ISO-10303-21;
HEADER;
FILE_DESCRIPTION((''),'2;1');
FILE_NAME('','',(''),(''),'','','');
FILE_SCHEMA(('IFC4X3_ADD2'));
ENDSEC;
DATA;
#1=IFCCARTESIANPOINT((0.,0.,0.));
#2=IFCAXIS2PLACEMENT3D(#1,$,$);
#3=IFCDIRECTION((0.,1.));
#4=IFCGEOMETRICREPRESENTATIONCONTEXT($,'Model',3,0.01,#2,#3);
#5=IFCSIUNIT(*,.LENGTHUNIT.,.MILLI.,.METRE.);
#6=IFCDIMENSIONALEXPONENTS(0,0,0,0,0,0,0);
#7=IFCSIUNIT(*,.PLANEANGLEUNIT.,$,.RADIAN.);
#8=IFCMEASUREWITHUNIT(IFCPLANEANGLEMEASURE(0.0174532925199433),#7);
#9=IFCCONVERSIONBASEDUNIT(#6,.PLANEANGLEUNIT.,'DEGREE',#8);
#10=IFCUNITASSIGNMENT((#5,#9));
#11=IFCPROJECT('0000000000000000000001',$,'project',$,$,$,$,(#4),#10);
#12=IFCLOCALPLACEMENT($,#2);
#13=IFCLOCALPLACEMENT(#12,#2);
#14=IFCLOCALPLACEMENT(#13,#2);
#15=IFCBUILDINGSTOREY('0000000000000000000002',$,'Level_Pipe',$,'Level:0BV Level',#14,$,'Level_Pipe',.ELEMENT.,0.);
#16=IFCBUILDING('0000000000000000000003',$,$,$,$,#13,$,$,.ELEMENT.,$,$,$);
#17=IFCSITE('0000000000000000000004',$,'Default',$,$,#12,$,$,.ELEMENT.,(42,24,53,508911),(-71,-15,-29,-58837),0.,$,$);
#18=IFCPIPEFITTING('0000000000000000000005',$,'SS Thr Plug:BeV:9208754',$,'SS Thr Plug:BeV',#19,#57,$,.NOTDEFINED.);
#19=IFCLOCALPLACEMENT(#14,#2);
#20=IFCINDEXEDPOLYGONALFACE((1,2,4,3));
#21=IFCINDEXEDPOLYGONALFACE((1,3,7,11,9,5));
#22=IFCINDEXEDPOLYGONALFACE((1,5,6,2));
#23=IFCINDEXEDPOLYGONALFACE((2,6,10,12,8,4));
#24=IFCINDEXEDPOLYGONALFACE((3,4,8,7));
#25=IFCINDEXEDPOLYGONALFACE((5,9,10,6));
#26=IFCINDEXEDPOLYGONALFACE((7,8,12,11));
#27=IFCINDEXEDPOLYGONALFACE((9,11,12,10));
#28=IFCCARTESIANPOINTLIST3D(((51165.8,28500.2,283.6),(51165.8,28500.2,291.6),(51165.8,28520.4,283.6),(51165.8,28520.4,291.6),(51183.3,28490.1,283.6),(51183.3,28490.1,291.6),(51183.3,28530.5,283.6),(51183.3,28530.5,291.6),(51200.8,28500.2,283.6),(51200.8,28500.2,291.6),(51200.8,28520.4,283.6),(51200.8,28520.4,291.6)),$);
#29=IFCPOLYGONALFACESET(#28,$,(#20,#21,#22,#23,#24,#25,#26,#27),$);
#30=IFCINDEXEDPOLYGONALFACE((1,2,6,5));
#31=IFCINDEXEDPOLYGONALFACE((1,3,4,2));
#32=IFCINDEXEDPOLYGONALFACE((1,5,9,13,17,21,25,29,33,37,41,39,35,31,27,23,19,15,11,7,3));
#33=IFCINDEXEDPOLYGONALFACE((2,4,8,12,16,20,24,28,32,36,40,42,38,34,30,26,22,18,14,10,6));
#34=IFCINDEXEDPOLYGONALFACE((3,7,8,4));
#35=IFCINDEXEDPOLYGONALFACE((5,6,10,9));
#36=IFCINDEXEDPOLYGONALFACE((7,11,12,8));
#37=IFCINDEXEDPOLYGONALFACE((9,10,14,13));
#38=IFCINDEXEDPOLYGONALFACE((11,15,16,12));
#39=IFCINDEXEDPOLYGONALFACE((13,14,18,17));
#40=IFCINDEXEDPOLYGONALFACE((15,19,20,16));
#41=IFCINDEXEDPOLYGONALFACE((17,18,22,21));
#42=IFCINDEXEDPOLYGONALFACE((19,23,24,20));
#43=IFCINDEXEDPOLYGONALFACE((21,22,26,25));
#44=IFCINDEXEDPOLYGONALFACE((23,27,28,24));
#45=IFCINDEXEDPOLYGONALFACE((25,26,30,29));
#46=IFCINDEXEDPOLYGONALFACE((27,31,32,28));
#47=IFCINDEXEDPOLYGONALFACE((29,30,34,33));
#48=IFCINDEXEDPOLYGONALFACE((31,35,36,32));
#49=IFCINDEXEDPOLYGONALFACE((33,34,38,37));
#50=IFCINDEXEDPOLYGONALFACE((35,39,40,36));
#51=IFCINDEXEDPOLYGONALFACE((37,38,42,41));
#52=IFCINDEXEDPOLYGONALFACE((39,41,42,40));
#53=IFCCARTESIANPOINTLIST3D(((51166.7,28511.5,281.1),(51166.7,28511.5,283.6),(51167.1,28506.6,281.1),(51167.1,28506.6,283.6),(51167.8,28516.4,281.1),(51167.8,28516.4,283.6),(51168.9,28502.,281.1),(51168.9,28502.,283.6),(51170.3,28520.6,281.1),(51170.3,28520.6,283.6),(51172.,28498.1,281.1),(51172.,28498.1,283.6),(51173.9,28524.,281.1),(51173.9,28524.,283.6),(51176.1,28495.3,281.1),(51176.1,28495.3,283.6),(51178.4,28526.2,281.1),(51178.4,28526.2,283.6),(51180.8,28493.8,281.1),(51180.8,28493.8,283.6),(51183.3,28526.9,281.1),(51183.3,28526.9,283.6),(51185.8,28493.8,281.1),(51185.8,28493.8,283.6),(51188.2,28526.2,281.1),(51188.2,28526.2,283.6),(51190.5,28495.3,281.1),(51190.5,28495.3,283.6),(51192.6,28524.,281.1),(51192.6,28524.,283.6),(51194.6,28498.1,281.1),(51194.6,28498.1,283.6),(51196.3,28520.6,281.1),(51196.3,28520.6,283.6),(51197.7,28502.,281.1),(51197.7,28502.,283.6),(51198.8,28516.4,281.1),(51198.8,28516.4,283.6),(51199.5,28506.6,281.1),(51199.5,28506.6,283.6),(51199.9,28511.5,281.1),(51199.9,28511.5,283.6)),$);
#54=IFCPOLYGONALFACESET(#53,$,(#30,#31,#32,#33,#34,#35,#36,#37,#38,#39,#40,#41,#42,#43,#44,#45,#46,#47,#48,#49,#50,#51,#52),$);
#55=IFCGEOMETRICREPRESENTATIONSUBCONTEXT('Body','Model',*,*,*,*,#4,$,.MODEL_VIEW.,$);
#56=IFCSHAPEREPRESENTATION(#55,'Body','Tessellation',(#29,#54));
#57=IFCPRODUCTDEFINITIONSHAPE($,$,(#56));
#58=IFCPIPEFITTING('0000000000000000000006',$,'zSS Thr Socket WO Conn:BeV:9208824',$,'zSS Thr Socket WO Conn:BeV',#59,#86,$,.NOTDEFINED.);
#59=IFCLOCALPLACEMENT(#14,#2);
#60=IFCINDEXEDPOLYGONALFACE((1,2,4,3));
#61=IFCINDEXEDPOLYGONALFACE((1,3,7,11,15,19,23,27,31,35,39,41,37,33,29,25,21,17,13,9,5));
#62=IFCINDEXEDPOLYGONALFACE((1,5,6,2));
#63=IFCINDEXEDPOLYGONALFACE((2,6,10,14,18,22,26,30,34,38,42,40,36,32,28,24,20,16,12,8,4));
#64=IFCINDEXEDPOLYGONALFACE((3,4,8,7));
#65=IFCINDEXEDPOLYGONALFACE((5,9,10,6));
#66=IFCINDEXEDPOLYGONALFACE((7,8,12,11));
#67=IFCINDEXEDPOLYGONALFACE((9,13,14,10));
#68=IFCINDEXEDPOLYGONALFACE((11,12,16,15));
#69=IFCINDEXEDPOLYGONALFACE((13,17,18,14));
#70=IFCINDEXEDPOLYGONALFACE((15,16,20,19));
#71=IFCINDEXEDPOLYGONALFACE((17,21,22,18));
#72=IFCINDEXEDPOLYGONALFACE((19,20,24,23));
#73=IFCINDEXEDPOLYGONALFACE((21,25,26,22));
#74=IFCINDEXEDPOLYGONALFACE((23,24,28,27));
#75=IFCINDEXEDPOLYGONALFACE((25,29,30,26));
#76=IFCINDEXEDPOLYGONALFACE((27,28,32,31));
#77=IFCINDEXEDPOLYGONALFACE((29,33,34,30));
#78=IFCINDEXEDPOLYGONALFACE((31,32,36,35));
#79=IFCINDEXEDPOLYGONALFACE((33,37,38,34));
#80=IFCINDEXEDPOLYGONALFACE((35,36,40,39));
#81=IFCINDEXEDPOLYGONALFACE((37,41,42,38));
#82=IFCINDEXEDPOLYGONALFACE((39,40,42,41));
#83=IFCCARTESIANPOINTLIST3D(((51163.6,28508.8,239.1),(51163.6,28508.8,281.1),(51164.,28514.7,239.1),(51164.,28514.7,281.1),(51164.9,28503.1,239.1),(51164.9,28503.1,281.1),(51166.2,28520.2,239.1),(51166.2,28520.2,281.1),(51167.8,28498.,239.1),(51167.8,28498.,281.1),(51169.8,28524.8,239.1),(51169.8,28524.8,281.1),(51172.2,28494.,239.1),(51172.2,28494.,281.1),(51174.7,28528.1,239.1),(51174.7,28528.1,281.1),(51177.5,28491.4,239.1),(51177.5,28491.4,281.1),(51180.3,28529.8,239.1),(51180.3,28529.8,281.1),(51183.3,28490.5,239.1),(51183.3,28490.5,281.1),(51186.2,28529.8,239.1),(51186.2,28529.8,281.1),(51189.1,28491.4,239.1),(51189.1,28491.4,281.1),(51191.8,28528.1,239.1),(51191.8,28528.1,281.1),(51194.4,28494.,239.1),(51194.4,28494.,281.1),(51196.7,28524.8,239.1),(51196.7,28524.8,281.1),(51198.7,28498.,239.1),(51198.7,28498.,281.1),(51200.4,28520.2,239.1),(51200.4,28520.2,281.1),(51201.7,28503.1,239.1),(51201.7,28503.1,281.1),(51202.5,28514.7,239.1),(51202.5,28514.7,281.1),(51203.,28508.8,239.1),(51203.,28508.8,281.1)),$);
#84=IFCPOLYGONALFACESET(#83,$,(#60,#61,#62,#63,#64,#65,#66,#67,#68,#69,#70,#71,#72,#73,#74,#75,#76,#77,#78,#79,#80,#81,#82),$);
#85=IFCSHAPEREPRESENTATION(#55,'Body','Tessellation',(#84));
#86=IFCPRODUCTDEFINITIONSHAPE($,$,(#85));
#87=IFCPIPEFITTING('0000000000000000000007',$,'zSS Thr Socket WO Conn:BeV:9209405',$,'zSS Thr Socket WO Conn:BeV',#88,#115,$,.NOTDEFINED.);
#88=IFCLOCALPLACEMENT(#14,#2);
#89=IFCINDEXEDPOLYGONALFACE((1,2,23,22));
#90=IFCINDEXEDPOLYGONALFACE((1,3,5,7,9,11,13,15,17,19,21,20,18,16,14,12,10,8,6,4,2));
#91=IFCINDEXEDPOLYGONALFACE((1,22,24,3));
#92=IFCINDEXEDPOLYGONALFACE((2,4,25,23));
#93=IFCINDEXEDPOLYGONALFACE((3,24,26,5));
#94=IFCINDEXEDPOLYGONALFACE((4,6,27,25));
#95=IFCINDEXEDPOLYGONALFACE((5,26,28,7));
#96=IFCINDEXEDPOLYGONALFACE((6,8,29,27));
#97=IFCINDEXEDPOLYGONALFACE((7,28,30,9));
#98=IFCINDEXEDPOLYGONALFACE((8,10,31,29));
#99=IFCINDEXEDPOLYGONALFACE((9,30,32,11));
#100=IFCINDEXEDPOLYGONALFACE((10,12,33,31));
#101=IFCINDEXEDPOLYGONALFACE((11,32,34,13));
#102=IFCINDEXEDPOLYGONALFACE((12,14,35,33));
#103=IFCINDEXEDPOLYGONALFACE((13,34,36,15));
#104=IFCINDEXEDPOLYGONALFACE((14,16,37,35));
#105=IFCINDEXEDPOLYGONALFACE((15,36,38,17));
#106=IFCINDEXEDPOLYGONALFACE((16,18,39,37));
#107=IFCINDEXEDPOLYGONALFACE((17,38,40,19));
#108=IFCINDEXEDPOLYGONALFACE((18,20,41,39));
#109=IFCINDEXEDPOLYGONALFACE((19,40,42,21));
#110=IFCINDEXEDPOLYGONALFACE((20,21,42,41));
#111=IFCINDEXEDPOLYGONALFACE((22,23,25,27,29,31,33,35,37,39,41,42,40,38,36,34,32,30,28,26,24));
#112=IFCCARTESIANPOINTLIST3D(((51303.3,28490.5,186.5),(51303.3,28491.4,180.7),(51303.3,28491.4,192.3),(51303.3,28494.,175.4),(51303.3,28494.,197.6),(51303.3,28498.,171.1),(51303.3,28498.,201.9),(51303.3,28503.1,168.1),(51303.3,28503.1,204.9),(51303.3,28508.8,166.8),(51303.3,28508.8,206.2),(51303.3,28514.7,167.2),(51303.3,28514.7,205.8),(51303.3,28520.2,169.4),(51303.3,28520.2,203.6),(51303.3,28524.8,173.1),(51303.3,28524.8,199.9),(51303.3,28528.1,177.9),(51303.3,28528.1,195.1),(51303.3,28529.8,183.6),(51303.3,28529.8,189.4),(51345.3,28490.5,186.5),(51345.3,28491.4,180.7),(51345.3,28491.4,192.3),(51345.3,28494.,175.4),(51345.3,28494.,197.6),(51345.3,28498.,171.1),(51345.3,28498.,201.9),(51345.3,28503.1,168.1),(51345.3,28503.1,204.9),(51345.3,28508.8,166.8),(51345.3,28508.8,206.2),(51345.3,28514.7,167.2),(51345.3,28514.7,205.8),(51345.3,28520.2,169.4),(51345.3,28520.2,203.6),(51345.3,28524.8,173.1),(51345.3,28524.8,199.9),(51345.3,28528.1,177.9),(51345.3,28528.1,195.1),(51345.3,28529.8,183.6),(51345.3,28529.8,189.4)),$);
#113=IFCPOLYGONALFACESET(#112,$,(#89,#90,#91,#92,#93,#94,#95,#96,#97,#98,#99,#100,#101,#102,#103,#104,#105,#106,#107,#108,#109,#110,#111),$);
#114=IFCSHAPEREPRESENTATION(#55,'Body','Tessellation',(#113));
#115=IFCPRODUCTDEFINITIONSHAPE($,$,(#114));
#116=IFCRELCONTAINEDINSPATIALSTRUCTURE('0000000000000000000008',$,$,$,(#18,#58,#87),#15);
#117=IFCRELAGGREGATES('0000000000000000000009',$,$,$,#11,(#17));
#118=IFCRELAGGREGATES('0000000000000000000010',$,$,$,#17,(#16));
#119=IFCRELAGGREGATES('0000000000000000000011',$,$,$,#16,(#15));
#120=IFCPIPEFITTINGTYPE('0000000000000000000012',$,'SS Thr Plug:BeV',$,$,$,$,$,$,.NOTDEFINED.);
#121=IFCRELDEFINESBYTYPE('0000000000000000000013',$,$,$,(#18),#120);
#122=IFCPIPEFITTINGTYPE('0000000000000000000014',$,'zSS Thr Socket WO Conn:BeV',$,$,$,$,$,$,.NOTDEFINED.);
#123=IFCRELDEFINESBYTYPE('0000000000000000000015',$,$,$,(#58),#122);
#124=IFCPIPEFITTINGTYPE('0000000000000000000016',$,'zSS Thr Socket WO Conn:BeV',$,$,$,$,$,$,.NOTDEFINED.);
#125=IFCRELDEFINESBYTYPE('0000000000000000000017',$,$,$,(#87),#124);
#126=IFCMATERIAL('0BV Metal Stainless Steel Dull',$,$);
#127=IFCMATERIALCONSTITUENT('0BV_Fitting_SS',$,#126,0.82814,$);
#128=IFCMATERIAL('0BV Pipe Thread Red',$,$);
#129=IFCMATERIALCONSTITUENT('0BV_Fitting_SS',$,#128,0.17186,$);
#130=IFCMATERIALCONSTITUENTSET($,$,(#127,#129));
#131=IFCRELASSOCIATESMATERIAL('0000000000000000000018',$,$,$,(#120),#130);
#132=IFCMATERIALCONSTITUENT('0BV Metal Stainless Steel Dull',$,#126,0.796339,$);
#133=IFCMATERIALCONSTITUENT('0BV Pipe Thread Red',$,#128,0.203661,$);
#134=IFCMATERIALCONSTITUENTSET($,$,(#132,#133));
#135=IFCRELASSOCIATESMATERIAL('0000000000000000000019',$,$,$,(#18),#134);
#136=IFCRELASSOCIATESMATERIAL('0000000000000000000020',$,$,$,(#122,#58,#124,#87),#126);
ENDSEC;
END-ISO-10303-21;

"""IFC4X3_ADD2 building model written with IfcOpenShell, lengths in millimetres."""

from ifc_helpers import new_model, entity, si_unit, converted_unit, direction, frame, frame_2d, origin, place, context, subcontext, project, spatial, polyline, circle, outline, extrude, source, transform, mapped, material, constituent, constituent_set, type_object, type_shapes, element, save


model = new_model("IFC4X3_ADD2")

# Units and contexts
model_context = context("Model", 3, precision=0.01, world=origin(), true_north=direction((0.0, 1.0)))
body_context = subcontext(model_context, "Body", "Model", "MODEL_VIEW")
ifc_project = project(units=[si_unit("LENGTHUNIT", "METRE", prefix="MILLI"), converted_unit("PLANEANGLEUNIT", "DEGREE", entity("IfcPlaneAngleMeasure", 0.0174532925199433), si_unit("PLANEANGLEUNIT", "RADIAN"), dimensions=[0, 0, 0, 0, 0, 0, 0])], contexts=[model_context])

# Site, building, storey
site_placement = place(None, origin())
site = spatial("IfcSite", under=ifc_project, at=site_placement, Name="Default", CompositionType="ELEMENT", RefLatitude=(42, 24, 53, 508911), RefLongitude=(-71, -15, -29, -58837), RefElevation=0.0)
building_placement = place(site_placement, origin())
building = spatial("IfcBuilding", under=site, at=building_placement, CompositionType="ELEMENT")
storey_placement = place(building_placement, origin())
storey = spatial("IfcBuildingStorey", under=building, at=storey_placement, Name="Level_Pipe", ObjectType="Level:0BV Level", LongName="Level_Pipe", CompositionType="ELEMENT", Elevation=0.0)

# Pipe fittings
ifc_material_1 = material(Name="0BV Metal Stainless Steel Dull")
ifc_material_2 = material(Name="0BV Pipe Thread Red")
ifc_constituent_1 = constituent(ifc_material_1, Name="0BV Metal Stainless Steel Dull", fraction=0.796339)
ifc_constituent_2 = constituent(ifc_material_2, Name="0BV Pipe Thread Red", fraction=0.203661)
ifc_constituent_set_1 = constituent_set(constituents=[ifc_constituent_1, ifc_constituent_2])
ifc_constituent_3 = constituent(ifc_material_1, Name="0BV_Fitting_SS", fraction=0.82814)
ifc_constituent_4 = constituent(ifc_material_2, Name="0BV_Fitting_SS", fraction=0.17186)
ifc_constituent_set_2 = constituent_set(constituents=[ifc_constituent_3, ifc_constituent_4])
pipe_fitting_type_1 = type_object("IfcPipeFittingType", Name="SS Thr Plug:BeV", PredefinedType="NOTDEFINED", material=ifc_constituent_set_2)
shared_shape_1 = source(origin(), body_context, "Body", "SweptSolid", [
    extrude(outline(polyline([(-10.1, -17.5), (10.1, -17.5), (20.2, 0.0), (10.1, 17.5), (-10.1, 17.5), (-20.2, 0.0), (-10.1, -17.5)])), frame((2.5, 0.0, 0.0), z_axis=(1.0, 0.0, 0.0), x_axis=(0.0, -0.5, -0.866025)), (0.0, 0.0, 1.0), 8.0),
    extrude(circle(Radius=16.6, at=frame_2d((0.0, 0.0), x_axis=(1.0, 0.0))), frame((0.0, 0.0, 0.0), z_axis=(1.0, 0.0, 0.0), x_axis=(0.0, 1.0, 0.0)), (0.0, 0.0, 1.0), 2.5),
])
type_shapes(pipe_fitting_type_1, [shared_shape_1])
pipe_fitting_1_placement = place(storey_placement, frame((51183.3, 28510.3, 281.1), z_axis=(-1.0, 0.0, 0.0), x_axis=(0.0, 0.0, 1.0)))
element("IfcPipeFitting", 1, at=pipe_fitting_1_placement, inside=storey, type_object=pipe_fitting_type_1, material=ifc_constituent_set_1, Name="SS Thr Plug:BeV:9208754", ObjectType="SS Thr Plug:BeV", PredefinedType="NOTDEFINED", context=body_context, shape_type="MappedRepresentation", body=[
    mapped(shared_shape_1, transform((0.0, 0.0, 0.0), scale=1.0)),
])
pipe_fitting_type_2 = type_object("IfcPipeFittingType", Name="zSS Thr Socket WO Conn:BeV", PredefinedType="NOTDEFINED", material=ifc_material_1)
shared_shape_2 = source(origin(), body_context, "Body", "SweptSolid", [
    extrude(circle(Radius=19.8, at=frame_2d((0.0, 0.0), x_axis=(1.0, 0.0))), frame((-21.0, 0.0, 0.0), z_axis=(1.0, 0.0, 0.0), x_axis=(0.0, 1.0, 0.0)), (0.0, 0.0, 1.0), 42.0),
])
type_shapes(pipe_fitting_type_2, [shared_shape_2])
pipe_fitting_2_placement = place(storey_placement, frame((51183.3, 28510.3, 260.1), z_axis=(-1.0, 0.0, 0.0), x_axis=(0.0, 0.0, -1.0)))
element("IfcPipeFitting", 2, at=pipe_fitting_2_placement, inside=storey, type_object=pipe_fitting_type_2, material=ifc_material_1, Name="zSS Thr Socket WO Conn:BeV:9208824", ObjectType="zSS Thr Socket WO Conn:BeV", PredefinedType="NOTDEFINED", context=body_context, shape_type="MappedRepresentation", body=[
    mapped(shared_shape_2, transform((0.0, 0.0, 0.0), scale=1.0)),
])
pipe_fitting_type_3 = type_object("IfcPipeFittingType", Name="zSS Thr Socket WO Conn:BeV", PredefinedType="NOTDEFINED", material=ifc_material_1)
shared_shape_3 = source(origin(), body_context, "Body", "SweptSolid", [
    extrude(circle(Radius=19.8, at=frame_2d((0.0, 0.0), x_axis=(1.0, 0.0))), frame((-21.0, 0.0, 0.0), z_axis=(1.0, 0.0, 0.0), x_axis=(0.0, -1.0, 0.0)), (0.0, 0.0, 1.0), 42.0),
])
type_shapes(pipe_fitting_type_3, [shared_shape_3])
pipe_fitting_3_placement = place(storey_placement, frame((51324.3, 28510.3, 186.5)))
element("IfcPipeFitting", 3, at=pipe_fitting_3_placement, inside=storey, type_object=pipe_fitting_type_3, material=ifc_material_1, Name="zSS Thr Socket WO Conn:BeV:9209405", ObjectType="zSS Thr Socket WO Conn:BeV", PredefinedType="NOTDEFINED", context=body_context, shape_type="MappedRepresentation", body=[
    mapped(shared_shape_3, transform((0.0, 0.0, 0.0), scale=1.0)),
])

save(model, "model.ifc")
